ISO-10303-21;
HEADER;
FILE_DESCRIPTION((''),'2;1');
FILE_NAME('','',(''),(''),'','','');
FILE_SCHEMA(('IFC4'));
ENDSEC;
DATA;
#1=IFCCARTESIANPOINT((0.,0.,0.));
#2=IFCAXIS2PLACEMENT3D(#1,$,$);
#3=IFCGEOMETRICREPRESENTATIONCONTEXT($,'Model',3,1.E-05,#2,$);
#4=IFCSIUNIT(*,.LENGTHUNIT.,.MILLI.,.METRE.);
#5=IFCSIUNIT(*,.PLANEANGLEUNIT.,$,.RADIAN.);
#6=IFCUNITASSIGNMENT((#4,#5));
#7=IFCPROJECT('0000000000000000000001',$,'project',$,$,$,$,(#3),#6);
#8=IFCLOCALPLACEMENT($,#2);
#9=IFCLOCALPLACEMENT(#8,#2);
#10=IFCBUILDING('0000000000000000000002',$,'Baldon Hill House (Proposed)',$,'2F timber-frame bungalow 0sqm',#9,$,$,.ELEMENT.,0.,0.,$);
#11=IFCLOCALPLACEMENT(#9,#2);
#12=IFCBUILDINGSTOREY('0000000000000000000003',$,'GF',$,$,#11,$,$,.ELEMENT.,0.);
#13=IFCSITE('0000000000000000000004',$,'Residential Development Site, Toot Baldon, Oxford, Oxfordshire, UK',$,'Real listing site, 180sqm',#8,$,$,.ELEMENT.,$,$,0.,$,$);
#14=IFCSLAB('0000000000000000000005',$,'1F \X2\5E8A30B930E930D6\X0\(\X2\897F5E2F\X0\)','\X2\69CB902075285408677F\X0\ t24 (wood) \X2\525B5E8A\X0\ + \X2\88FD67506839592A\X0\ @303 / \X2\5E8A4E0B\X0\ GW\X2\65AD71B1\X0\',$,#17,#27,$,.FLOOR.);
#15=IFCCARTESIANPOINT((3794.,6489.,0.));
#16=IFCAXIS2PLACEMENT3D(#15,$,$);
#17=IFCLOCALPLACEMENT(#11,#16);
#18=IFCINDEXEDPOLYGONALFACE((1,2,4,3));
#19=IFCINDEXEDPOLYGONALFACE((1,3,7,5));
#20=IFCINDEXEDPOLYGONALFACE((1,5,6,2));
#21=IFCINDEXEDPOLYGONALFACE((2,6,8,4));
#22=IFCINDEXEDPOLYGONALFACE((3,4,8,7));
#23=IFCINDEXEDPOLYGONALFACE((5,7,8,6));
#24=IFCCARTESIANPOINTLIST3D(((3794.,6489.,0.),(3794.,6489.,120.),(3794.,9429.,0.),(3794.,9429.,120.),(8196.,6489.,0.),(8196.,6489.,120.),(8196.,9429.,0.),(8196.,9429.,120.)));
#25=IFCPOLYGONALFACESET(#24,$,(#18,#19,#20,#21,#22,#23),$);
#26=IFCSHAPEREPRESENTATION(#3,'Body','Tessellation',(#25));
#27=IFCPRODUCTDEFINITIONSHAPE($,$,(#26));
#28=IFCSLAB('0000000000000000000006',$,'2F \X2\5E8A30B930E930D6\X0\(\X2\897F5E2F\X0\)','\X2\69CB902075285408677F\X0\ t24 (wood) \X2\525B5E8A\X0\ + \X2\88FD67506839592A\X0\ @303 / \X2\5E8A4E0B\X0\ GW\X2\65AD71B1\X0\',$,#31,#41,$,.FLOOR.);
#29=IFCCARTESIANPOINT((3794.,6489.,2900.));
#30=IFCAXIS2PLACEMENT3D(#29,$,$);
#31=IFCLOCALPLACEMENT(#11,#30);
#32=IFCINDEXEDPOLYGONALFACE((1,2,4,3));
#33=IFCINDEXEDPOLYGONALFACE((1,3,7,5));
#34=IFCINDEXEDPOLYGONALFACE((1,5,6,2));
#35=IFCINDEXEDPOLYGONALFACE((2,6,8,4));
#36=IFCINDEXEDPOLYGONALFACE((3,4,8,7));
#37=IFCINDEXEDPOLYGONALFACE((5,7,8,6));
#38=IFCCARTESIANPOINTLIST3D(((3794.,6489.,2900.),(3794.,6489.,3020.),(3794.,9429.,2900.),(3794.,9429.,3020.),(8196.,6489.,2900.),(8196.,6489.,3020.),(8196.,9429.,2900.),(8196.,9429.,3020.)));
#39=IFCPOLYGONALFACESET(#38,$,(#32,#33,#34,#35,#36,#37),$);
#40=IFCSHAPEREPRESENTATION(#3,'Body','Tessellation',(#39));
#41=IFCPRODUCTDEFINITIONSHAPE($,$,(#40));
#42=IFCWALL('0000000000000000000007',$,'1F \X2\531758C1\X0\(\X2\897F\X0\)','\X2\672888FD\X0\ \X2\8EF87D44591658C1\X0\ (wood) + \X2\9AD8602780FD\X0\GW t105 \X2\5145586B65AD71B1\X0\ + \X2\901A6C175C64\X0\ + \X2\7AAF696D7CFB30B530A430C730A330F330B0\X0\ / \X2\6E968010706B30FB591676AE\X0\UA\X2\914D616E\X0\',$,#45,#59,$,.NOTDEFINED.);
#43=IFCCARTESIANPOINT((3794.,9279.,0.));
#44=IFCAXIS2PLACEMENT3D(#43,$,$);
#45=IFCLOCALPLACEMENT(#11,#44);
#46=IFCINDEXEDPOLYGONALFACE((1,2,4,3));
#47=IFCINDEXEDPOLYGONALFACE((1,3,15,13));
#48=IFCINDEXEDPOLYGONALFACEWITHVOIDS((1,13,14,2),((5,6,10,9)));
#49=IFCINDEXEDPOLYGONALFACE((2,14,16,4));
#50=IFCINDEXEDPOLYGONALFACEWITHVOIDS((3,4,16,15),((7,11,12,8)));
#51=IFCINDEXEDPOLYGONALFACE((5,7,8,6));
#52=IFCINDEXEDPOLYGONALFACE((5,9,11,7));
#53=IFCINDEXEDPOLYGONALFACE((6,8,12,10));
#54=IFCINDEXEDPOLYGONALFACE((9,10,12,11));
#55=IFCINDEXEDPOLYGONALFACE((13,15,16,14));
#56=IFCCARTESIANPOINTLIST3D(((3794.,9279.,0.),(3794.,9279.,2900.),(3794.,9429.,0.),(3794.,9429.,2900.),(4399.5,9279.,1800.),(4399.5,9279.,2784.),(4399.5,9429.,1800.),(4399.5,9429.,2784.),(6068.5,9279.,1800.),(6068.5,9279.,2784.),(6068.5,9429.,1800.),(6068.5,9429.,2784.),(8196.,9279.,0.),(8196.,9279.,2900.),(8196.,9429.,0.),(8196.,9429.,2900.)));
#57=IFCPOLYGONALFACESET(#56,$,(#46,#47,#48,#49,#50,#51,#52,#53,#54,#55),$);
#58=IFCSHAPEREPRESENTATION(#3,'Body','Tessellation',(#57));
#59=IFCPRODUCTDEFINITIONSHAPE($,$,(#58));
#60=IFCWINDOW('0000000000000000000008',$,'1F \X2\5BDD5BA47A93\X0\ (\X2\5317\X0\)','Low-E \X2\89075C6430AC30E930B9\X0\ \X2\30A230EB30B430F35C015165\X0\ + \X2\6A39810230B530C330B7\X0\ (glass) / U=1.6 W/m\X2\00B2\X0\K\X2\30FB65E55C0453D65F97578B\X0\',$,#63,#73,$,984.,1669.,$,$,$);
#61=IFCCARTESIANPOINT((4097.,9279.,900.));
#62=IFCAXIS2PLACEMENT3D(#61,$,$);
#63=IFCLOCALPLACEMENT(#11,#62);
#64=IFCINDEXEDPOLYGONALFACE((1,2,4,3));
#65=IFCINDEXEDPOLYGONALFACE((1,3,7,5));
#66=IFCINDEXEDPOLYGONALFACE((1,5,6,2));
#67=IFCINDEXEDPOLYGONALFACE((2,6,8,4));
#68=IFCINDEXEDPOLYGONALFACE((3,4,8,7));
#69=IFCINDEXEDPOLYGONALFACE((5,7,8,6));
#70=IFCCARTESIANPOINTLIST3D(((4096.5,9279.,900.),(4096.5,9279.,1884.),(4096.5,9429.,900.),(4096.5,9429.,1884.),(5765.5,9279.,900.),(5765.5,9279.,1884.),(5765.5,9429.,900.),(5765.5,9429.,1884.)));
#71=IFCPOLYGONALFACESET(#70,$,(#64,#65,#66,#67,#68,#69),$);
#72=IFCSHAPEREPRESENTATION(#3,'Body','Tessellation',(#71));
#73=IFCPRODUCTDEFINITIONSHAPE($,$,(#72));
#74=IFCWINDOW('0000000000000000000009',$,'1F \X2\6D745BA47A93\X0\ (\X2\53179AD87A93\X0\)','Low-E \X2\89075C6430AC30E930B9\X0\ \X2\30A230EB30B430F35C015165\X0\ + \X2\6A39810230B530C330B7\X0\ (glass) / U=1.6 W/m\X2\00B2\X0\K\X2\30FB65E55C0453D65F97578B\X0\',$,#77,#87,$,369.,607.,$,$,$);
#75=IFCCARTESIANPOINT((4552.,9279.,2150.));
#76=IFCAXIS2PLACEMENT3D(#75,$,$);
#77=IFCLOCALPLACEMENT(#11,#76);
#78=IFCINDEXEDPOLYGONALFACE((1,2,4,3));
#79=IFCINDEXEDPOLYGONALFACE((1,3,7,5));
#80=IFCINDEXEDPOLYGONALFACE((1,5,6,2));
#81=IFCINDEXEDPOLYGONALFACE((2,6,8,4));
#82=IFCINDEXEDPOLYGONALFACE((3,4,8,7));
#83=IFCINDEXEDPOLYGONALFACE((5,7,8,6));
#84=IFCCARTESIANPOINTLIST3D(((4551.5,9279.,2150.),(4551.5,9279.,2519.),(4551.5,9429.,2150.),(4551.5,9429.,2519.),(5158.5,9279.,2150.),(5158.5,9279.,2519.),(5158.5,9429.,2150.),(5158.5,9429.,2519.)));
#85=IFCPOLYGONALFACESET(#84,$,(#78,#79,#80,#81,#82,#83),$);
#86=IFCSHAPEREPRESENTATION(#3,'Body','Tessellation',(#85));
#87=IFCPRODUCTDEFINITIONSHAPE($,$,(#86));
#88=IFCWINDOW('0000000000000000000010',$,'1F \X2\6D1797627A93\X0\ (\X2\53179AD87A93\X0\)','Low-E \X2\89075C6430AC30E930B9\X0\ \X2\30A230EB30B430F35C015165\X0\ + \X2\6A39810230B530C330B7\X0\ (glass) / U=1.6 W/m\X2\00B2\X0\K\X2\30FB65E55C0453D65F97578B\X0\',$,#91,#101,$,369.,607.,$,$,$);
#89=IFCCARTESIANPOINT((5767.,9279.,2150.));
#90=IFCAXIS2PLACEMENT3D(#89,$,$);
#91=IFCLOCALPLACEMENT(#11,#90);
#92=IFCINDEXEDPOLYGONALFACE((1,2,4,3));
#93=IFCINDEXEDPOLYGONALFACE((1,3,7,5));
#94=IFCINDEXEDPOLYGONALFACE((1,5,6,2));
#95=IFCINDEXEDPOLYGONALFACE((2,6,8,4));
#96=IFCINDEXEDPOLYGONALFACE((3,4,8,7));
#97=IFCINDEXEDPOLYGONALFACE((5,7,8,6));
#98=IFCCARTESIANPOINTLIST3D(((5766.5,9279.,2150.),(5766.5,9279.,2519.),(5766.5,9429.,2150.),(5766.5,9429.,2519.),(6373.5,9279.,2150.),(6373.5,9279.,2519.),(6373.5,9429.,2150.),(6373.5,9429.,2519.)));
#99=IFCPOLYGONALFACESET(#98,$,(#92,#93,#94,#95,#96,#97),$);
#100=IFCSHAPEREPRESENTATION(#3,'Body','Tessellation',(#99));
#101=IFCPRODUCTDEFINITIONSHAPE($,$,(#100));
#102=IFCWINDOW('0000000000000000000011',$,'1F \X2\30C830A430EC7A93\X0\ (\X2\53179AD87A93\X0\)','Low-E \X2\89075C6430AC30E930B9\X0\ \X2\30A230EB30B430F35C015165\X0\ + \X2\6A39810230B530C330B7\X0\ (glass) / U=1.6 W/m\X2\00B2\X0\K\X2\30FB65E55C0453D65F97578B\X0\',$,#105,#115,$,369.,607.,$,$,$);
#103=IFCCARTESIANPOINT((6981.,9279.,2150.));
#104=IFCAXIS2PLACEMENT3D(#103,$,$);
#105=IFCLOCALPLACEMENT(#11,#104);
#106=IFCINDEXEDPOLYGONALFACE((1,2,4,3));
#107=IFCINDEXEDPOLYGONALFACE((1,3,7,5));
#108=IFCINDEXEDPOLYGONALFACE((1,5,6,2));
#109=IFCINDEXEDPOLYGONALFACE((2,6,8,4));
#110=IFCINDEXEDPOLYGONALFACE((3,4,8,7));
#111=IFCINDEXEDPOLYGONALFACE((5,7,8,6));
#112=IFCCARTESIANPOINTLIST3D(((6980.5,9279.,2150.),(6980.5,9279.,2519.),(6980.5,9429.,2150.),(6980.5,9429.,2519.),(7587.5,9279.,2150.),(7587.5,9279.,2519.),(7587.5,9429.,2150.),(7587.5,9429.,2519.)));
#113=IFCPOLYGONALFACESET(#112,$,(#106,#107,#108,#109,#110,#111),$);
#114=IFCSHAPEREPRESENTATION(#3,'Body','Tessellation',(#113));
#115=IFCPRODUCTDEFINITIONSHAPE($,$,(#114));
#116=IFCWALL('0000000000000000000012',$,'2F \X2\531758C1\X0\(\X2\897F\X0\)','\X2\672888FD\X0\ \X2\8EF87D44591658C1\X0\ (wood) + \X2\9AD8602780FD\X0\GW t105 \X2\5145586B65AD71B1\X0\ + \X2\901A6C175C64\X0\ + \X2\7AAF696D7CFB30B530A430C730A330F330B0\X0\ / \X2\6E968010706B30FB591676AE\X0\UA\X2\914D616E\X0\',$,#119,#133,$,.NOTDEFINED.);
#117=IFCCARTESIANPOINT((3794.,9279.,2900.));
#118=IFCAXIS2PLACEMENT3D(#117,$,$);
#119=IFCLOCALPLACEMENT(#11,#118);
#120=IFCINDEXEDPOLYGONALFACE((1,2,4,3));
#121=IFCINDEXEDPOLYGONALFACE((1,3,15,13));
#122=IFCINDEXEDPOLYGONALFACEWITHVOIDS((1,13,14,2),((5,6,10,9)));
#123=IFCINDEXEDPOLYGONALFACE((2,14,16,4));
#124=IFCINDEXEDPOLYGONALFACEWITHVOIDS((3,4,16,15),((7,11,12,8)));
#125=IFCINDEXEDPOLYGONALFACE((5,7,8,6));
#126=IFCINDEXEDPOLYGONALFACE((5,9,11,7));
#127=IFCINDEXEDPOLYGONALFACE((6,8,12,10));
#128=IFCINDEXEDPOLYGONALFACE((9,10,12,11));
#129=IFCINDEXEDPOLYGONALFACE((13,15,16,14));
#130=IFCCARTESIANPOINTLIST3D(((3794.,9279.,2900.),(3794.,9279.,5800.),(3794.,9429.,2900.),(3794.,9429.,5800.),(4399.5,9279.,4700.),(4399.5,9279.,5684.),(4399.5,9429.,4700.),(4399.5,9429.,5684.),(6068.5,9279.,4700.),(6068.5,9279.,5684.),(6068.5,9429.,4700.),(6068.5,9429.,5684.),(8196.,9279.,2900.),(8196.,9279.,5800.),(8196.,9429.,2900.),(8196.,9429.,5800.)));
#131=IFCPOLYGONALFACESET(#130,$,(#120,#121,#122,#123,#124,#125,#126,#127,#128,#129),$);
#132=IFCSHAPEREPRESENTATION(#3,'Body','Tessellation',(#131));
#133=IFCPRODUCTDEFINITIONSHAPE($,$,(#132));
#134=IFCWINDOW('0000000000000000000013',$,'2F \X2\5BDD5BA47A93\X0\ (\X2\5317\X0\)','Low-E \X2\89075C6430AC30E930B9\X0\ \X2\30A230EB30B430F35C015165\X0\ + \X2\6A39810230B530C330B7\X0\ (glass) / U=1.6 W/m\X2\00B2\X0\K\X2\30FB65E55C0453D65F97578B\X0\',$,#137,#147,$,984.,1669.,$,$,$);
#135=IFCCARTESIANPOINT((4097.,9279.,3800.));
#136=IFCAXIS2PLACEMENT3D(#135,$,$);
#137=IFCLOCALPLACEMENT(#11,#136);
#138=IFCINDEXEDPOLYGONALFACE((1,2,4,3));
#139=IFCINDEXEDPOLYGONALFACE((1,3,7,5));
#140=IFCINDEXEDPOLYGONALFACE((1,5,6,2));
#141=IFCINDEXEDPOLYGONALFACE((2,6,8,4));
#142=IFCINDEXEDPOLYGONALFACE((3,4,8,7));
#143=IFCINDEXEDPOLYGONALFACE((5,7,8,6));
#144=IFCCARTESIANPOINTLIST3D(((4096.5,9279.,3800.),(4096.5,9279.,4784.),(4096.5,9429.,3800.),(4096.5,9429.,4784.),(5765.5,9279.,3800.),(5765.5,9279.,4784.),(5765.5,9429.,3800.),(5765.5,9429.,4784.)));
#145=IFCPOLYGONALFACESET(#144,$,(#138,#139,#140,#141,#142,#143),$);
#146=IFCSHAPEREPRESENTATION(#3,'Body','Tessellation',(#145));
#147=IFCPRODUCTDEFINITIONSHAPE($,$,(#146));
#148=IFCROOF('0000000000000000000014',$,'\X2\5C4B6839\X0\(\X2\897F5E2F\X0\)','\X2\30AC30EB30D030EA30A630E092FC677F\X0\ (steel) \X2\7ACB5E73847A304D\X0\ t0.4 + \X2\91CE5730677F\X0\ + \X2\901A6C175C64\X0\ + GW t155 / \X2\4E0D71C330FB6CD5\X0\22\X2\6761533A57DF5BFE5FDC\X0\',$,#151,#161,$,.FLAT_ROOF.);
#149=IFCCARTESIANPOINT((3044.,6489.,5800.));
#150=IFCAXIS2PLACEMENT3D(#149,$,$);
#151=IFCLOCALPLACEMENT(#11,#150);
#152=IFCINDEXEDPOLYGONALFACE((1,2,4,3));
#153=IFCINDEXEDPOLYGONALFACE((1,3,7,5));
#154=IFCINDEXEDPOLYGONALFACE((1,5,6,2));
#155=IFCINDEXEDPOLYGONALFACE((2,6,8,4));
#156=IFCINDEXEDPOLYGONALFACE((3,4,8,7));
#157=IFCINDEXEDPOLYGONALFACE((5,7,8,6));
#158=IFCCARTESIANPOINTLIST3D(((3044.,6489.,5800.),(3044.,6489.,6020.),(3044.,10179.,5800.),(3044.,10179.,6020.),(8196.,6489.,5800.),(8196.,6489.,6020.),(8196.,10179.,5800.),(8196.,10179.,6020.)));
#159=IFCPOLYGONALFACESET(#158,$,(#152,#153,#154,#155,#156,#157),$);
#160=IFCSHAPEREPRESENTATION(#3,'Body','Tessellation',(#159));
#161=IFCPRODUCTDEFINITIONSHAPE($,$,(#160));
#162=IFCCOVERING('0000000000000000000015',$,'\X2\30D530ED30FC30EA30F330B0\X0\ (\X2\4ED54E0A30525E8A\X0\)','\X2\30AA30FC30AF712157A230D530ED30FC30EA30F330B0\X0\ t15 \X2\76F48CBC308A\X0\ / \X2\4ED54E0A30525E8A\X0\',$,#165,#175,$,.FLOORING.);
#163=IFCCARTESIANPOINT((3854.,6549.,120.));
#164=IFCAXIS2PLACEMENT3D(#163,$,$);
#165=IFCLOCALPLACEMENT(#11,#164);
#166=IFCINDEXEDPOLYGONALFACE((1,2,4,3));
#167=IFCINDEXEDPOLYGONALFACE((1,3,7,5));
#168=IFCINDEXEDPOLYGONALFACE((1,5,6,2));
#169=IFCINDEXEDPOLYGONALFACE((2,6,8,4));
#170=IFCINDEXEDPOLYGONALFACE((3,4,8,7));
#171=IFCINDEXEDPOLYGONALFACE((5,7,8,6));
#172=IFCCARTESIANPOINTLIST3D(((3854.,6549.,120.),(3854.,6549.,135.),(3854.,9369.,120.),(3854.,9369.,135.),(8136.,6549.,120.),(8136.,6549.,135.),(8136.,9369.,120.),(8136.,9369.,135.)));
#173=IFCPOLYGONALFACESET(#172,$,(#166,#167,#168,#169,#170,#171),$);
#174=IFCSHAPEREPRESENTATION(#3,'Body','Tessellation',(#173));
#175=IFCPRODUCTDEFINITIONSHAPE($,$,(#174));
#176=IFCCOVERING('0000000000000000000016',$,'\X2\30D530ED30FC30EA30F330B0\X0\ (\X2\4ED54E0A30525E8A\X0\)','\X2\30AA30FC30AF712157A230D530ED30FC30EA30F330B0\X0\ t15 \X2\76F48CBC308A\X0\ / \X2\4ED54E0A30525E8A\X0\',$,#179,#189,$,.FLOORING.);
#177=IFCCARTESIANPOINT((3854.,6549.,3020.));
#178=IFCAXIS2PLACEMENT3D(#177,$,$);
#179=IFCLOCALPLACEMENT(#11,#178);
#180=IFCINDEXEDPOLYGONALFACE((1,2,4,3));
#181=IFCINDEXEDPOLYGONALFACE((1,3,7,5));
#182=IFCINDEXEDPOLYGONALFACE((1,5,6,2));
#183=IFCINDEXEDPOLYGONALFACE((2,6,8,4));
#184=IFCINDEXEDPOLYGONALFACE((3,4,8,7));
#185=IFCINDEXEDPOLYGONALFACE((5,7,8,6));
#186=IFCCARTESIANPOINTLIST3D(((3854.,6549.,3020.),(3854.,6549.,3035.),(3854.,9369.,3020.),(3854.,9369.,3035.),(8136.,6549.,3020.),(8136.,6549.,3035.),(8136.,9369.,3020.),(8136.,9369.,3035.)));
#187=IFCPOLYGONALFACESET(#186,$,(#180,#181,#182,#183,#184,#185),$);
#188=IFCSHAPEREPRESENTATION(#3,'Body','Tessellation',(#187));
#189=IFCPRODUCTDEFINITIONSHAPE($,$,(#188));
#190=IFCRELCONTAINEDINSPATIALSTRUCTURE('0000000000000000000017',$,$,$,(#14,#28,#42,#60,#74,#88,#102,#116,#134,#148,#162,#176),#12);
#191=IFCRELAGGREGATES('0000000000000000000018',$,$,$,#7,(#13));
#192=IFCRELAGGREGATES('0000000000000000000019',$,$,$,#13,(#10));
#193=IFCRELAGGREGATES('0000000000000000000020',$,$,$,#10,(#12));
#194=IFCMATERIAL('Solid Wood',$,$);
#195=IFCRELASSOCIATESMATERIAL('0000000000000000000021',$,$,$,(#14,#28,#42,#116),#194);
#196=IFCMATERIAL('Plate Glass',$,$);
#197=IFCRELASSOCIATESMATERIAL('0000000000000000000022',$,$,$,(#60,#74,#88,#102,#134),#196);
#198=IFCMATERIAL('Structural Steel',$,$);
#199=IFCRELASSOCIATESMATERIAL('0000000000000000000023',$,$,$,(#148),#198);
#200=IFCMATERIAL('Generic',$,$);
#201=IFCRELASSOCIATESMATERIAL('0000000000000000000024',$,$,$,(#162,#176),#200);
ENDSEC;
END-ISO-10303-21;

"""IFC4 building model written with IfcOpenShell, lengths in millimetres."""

from ifc_helpers import new_model, si_unit, frame, frame_2d, origin, place, context, project, spatial, rectangle, extrude, material, element, fill, save


model = new_model("IFC4")

# Units and contexts
model_context = context("Model", 3, precision=1e-05, world=origin())
ifc_project = project(units=[si_unit("LENGTHUNIT", "METRE", prefix="MILLI"), si_unit("PLANEANGLEUNIT", "RADIAN")], contexts=[model_context])

# Site, building, storey
site_placement = place(None, origin())
site = spatial("IfcSite", under=ifc_project, at=site_placement, Name="Residential Development Site, Toot Baldon, Oxford, Oxfordshire, UK", ObjectType="Real listing site, 180sqm", CompositionType="ELEMENT", RefElevation=0.0)
building_placement = place(site_placement, origin())
building = spatial("IfcBuilding", under=site, at=building_placement, Name="Baldon Hill House (Proposed)", ObjectType="2F timber-frame bungalow 0sqm", CompositionType="ELEMENT", ElevationOfRefHeight=0.0, ElevationOfTerrain=0.0)
storey_placement = place(building_placement, origin())
storey = spatial("IfcBuildingStorey", under=building, at=storey_placement, Name="GF", CompositionType="ELEMENT", Elevation=0.0)

# Slabs
ifc_material_1 = material(Name="Solid Wood")
slab_1_placement = place(storey_placement, frame((3794.0, 6489.0, 0.0)))
element("IfcSlab", 1, at=slab_1_placement, inside=storey, material=ifc_material_1, Name="1F 床スラブ(西帯)", Description="構造用合板 t24 (wood) 剛床 + 製材根太 @303 / 床下 GW断熱", PredefinedType="FLOOR", context=model_context, shape_type="SweptSolid", body=[
    extrude(rectangle(XDim=4402.0, YDim=2940.0, at=frame_2d((2201.0, 1470.0))), frame((3794.0, 6489.0, 0.0)), (0.0, 0.0, 1.0), 120.0),
])
slab_2_placement = place(storey_placement, frame((3794.0, 6489.0, 2900.0)))
element("IfcSlab", 2, at=slab_2_placement, inside=storey, material=ifc_material_1, Name="2F 床スラブ(西帯)", Description="構造用合板 t24 (wood) 剛床 + 製材根太 @303 / 床下 GW断熱", PredefinedType="FLOOR", context=model_context, shape_type="SweptSolid", body=[
    extrude(rectangle(XDim=4402.0, YDim=2940.0, at=frame_2d((2201.0, 1470.0))), frame((3794.0, 6489.0, 2900.0)), (0.0, 0.0, 1.0), 120.0),
])

# Wall, openings, windows
wall_1_placement = place(storey_placement, frame((3794.0, 9279.0, 0.0)))
wall_1 = element("IfcWall", 3, at=wall_1_placement, inside=storey, material=ifc_material_1, Name="1F 北壁(西)", Description="木製 軸組外壁 (wood) + 高性能GW t105 充填断熱 + 通気層 + 窯業系サイディング / 準耐火・外皮UA配慮", PredefinedType="NOTDEFINED", context=model_context, shape_type="SweptSolid", body=[
    extrude(rectangle(XDim=4402.0, YDim=150.0, at=frame_2d((2201.0, 75.0))), frame((3794.0, 9279.0, 0.0)), (0.0, 0.0, 1.0), 2900.0),
])
opening_1_placement = place(storey_placement, frame((4097.0, 9279.0, 900.0)))
opening_1 = element("IfcOpeningElement", 4, at=opening_1_placement, cuts=wall_1, PredefinedType="NOTDEFINED", context=model_context, shape_type="SweptSolid", body=[
    extrude(rectangle(XDim=1669.0, YDim=150.0, at=frame_2d((834.0, 75.0))), frame((4097.0, 9279.0, 900.0)), (0.0, 0.0, 1.0), 984.0),
])
opening_2_placement = place(storey_placement, frame((4552.0, 9279.0, 2150.0)))
opening_2 = element("IfcOpeningElement", 5, at=opening_2_placement, cuts=wall_1, PredefinedType="NOTDEFINED", context=model_context, shape_type="SweptSolid", body=[
    extrude(rectangle(XDim=607.0, YDim=150.0, at=frame_2d((303.0, 75.0))), frame((4552.0, 9279.0, 2150.0)), (0.0, 0.0, 1.0), 369.0),
])
opening_3_placement = place(storey_placement, frame((5767.0, 9279.0, 2150.0)))
opening_3 = element("IfcOpeningElement", 6, at=opening_3_placement, cuts=wall_1, PredefinedType="NOTDEFINED", context=model_context, shape_type="SweptSolid", body=[
    extrude(rectangle(XDim=607.0, YDim=150.0, at=frame_2d((303.0, 75.0))), frame((5767.0, 9279.0, 2150.0)), (0.0, 0.0, 1.0), 369.0),
])
opening_4_placement = place(storey_placement, frame((6981.0, 9279.0, 2150.0)))
opening_4 = element("IfcOpeningElement", 7, at=opening_4_placement, cuts=wall_1, PredefinedType="NOTDEFINED", context=model_context, shape_type="SweptSolid", body=[
    extrude(rectangle(XDim=607.0, YDim=150.0, at=frame_2d((303.0, 75.0))), frame((6981.0, 9279.0, 2150.0)), (0.0, 0.0, 1.0), 369.0),
])
ifc_material_2 = material(Name="Plate Glass")
window_1_placement = place(storey_placement, frame((4097.0, 9279.0, 900.0)))
window_1 = element("IfcWindow", 8, at=window_1_placement, inside=storey, material=ifc_material_2, Name="1F 寝室窓 (北)", Description="Low-E 複層ガラス アルゴン封入 + 樹脂サッシ (glass) / U=1.6 W/m²K・日射取得型", OverallHeight=984.0, OverallWidth=1669.0, context=model_context, shape_type="SweptSolid", body=[
    extrude(rectangle(XDim=1669.0, YDim=150.0, at=frame_2d((834.0, 75.0))), frame((4097.0, 9279.0, 900.0)), (0.0, 0.0, 1.0), 984.0),
])
fill(opening_1, window_1)
window_2_placement = place(storey_placement, frame((4552.0, 9279.0, 2150.0)))
window_2 = element("IfcWindow", 9, at=window_2_placement, inside=storey, material=ifc_material_2, Name="1F 浴室窓 (北高窓)", Description="Low-E 複層ガラス アルゴン封入 + 樹脂サッシ (glass) / U=1.6 W/m²K・日射取得型", OverallHeight=369.0, OverallWidth=607.0, context=model_context, shape_type="SweptSolid", body=[
    extrude(rectangle(XDim=607.0, YDim=150.0, at=frame_2d((303.0, 75.0))), frame((4552.0, 9279.0, 2150.0)), (0.0, 0.0, 1.0), 369.0),
])
fill(opening_2, window_2)
window_3_placement = place(storey_placement, frame((5767.0, 9279.0, 2150.0)))
window_3 = element("IfcWindow", 10, at=window_3_placement, inside=storey, material=ifc_material_2, Name="1F 洗面窓 (北高窓)", Description="Low-E 複層ガラス アルゴン封入 + 樹脂サッシ (glass) / U=1.6 W/m²K・日射取得型", OverallHeight=369.0, OverallWidth=607.0, context=model_context, shape_type="SweptSolid", body=[
    extrude(rectangle(XDim=607.0, YDim=150.0, at=frame_2d((303.0, 75.0))), frame((5767.0, 9279.0, 2150.0)), (0.0, 0.0, 1.0), 369.0),
])
fill(opening_3, window_3)
window_4_placement = place(storey_placement, frame((6981.0, 9279.0, 2150.0)))
window_4 = element("IfcWindow", 11, at=window_4_placement, inside=storey, material=ifc_material_2, Name="1F トイレ窓 (北高窓)", Description="Low-E 複層ガラス アルゴン封入 + 樹脂サッシ (glass) / U=1.6 W/m²K・日射取得型", OverallHeight=369.0, OverallWidth=607.0, context=model_context, shape_type="SweptSolid", body=[
    extrude(rectangle(XDim=607.0, YDim=150.0, at=frame_2d((303.0, 75.0))), frame((6981.0, 9279.0, 2150.0)), (0.0, 0.0, 1.0), 369.0),
])
fill(opening_4, window_4)

# Wall, opening, window
wall_2_placement = place(storey_placement, frame((3794.0, 9279.0, 2900.0)))
wall_2 = element("IfcWall", 12, at=wall_2_placement, inside=storey, material=ifc_material_1, Name="2F 北壁(西)", Description="木製 軸組外壁 (wood) + 高性能GW t105 充填断熱 + 通気層 + 窯業系サイディング / 準耐火・外皮UA配慮", PredefinedType="NOTDEFINED", context=model_context, shape_type="SweptSolid", body=[
    extrude(rectangle(XDim=4402.0, YDim=150.0, at=frame_2d((2201.0, 75.0))), frame((3794.0, 9279.0, 2900.0)), (0.0, 0.0, 1.0), 2900.0),
])
opening_5_placement = place(storey_placement, frame((4097.0, 9279.0, 3800.0)))
opening_5 = element("IfcOpeningElement", 13, at=opening_5_placement, cuts=wall_2, PredefinedType="NOTDEFINED", context=model_context, shape_type="SweptSolid", body=[
    extrude(rectangle(XDim=1669.0, YDim=150.0, at=frame_2d((834.0, 75.0))), frame((4097.0, 9279.0, 3800.0)), (0.0, 0.0, 1.0), 984.0),
])
window_5_placement = place(storey_placement, frame((4097.0, 9279.0, 3800.0)))
window_5 = element("IfcWindow", 14, at=window_5_placement, inside=storey, material=ifc_material_2, Name="2F 寝室窓 (北)", Description="Low-E 複層ガラス アルゴン封入 + 樹脂サッシ (glass) / U=1.6 W/m²K・日射取得型", OverallHeight=984.0, OverallWidth=1669.0, context=model_context, shape_type="SweptSolid", body=[
    extrude(rectangle(XDim=1669.0, YDim=150.0, at=frame_2d((834.0, 75.0))), frame((4097.0, 9279.0, 3800.0)), (0.0, 0.0, 1.0), 984.0),
])
fill(opening_5, window_5)

# Roof
ifc_material_3 = material(Name="Structural Steel")
for number, where, name in (
    (15, (3044.0, 6489.0, 5800.0), "屋根(西帯)"),
):
    element("IfcRoof", number, at=place(storey_placement, frame(where)), inside=storey, material=ifc_material_3, Name=name, Description="ガルバリウム鋼板 (steel) 立平葺き t0.4 + 野地板 + 通気層 + GW t155 / 不燃・法22条区域対応", PredefinedType="FLAT_ROOF", context=model_context, shape_type="SweptSolid", body=[
        extrude(rectangle(XDim=5152.0, YDim=3690.0, at=frame_2d((2576.0, 1845.0))), frame((3044.0, 6489.0, 5800.0)), (0.0, 0.0, 1.0), 220.0),
    ])

# Coverings
ifc_material_4 = material(Name="Generic")
covering_1_placement = place(storey_placement, frame((3854.0, 6549.0, 120.0)))
element("IfcCovering", 16, at=covering_1_placement, inside=storey, material=ifc_material_4, Name="フローリング (仕上げ床)", Description="オーク無垢フローリング t15 直貼り / 仕上げ床", PredefinedType="FLOORING", context=model_context, shape_type="SweptSolid", body=[
    extrude(rectangle(XDim=4282.0, YDim=2820.0, at=frame_2d((2141.0, 1410.0))), frame((3854.0, 6549.0, 120.0)), (0.0, 0.0, 1.0), 15.0),
])
covering_2_placement = place(storey_placement, frame((3854.0, 6549.0, 3020.0)))
element("IfcCovering", 17, at=covering_2_placement, inside=storey, material=ifc_material_4, Name="フローリング (仕上げ床)", Description="オーク無垢フローリング t15 直貼り / 仕上げ床", PredefinedType="FLOORING", context=model_context, shape_type="SweptSolid", body=[
    extrude(rectangle(XDim=4282.0, YDim=2820.0, at=frame_2d((2141.0, 1410.0))), frame((3854.0, 6549.0, 3020.0)), (0.0, 0.0, 1.0), 15.0),
])

save(model, "model.ifc")
